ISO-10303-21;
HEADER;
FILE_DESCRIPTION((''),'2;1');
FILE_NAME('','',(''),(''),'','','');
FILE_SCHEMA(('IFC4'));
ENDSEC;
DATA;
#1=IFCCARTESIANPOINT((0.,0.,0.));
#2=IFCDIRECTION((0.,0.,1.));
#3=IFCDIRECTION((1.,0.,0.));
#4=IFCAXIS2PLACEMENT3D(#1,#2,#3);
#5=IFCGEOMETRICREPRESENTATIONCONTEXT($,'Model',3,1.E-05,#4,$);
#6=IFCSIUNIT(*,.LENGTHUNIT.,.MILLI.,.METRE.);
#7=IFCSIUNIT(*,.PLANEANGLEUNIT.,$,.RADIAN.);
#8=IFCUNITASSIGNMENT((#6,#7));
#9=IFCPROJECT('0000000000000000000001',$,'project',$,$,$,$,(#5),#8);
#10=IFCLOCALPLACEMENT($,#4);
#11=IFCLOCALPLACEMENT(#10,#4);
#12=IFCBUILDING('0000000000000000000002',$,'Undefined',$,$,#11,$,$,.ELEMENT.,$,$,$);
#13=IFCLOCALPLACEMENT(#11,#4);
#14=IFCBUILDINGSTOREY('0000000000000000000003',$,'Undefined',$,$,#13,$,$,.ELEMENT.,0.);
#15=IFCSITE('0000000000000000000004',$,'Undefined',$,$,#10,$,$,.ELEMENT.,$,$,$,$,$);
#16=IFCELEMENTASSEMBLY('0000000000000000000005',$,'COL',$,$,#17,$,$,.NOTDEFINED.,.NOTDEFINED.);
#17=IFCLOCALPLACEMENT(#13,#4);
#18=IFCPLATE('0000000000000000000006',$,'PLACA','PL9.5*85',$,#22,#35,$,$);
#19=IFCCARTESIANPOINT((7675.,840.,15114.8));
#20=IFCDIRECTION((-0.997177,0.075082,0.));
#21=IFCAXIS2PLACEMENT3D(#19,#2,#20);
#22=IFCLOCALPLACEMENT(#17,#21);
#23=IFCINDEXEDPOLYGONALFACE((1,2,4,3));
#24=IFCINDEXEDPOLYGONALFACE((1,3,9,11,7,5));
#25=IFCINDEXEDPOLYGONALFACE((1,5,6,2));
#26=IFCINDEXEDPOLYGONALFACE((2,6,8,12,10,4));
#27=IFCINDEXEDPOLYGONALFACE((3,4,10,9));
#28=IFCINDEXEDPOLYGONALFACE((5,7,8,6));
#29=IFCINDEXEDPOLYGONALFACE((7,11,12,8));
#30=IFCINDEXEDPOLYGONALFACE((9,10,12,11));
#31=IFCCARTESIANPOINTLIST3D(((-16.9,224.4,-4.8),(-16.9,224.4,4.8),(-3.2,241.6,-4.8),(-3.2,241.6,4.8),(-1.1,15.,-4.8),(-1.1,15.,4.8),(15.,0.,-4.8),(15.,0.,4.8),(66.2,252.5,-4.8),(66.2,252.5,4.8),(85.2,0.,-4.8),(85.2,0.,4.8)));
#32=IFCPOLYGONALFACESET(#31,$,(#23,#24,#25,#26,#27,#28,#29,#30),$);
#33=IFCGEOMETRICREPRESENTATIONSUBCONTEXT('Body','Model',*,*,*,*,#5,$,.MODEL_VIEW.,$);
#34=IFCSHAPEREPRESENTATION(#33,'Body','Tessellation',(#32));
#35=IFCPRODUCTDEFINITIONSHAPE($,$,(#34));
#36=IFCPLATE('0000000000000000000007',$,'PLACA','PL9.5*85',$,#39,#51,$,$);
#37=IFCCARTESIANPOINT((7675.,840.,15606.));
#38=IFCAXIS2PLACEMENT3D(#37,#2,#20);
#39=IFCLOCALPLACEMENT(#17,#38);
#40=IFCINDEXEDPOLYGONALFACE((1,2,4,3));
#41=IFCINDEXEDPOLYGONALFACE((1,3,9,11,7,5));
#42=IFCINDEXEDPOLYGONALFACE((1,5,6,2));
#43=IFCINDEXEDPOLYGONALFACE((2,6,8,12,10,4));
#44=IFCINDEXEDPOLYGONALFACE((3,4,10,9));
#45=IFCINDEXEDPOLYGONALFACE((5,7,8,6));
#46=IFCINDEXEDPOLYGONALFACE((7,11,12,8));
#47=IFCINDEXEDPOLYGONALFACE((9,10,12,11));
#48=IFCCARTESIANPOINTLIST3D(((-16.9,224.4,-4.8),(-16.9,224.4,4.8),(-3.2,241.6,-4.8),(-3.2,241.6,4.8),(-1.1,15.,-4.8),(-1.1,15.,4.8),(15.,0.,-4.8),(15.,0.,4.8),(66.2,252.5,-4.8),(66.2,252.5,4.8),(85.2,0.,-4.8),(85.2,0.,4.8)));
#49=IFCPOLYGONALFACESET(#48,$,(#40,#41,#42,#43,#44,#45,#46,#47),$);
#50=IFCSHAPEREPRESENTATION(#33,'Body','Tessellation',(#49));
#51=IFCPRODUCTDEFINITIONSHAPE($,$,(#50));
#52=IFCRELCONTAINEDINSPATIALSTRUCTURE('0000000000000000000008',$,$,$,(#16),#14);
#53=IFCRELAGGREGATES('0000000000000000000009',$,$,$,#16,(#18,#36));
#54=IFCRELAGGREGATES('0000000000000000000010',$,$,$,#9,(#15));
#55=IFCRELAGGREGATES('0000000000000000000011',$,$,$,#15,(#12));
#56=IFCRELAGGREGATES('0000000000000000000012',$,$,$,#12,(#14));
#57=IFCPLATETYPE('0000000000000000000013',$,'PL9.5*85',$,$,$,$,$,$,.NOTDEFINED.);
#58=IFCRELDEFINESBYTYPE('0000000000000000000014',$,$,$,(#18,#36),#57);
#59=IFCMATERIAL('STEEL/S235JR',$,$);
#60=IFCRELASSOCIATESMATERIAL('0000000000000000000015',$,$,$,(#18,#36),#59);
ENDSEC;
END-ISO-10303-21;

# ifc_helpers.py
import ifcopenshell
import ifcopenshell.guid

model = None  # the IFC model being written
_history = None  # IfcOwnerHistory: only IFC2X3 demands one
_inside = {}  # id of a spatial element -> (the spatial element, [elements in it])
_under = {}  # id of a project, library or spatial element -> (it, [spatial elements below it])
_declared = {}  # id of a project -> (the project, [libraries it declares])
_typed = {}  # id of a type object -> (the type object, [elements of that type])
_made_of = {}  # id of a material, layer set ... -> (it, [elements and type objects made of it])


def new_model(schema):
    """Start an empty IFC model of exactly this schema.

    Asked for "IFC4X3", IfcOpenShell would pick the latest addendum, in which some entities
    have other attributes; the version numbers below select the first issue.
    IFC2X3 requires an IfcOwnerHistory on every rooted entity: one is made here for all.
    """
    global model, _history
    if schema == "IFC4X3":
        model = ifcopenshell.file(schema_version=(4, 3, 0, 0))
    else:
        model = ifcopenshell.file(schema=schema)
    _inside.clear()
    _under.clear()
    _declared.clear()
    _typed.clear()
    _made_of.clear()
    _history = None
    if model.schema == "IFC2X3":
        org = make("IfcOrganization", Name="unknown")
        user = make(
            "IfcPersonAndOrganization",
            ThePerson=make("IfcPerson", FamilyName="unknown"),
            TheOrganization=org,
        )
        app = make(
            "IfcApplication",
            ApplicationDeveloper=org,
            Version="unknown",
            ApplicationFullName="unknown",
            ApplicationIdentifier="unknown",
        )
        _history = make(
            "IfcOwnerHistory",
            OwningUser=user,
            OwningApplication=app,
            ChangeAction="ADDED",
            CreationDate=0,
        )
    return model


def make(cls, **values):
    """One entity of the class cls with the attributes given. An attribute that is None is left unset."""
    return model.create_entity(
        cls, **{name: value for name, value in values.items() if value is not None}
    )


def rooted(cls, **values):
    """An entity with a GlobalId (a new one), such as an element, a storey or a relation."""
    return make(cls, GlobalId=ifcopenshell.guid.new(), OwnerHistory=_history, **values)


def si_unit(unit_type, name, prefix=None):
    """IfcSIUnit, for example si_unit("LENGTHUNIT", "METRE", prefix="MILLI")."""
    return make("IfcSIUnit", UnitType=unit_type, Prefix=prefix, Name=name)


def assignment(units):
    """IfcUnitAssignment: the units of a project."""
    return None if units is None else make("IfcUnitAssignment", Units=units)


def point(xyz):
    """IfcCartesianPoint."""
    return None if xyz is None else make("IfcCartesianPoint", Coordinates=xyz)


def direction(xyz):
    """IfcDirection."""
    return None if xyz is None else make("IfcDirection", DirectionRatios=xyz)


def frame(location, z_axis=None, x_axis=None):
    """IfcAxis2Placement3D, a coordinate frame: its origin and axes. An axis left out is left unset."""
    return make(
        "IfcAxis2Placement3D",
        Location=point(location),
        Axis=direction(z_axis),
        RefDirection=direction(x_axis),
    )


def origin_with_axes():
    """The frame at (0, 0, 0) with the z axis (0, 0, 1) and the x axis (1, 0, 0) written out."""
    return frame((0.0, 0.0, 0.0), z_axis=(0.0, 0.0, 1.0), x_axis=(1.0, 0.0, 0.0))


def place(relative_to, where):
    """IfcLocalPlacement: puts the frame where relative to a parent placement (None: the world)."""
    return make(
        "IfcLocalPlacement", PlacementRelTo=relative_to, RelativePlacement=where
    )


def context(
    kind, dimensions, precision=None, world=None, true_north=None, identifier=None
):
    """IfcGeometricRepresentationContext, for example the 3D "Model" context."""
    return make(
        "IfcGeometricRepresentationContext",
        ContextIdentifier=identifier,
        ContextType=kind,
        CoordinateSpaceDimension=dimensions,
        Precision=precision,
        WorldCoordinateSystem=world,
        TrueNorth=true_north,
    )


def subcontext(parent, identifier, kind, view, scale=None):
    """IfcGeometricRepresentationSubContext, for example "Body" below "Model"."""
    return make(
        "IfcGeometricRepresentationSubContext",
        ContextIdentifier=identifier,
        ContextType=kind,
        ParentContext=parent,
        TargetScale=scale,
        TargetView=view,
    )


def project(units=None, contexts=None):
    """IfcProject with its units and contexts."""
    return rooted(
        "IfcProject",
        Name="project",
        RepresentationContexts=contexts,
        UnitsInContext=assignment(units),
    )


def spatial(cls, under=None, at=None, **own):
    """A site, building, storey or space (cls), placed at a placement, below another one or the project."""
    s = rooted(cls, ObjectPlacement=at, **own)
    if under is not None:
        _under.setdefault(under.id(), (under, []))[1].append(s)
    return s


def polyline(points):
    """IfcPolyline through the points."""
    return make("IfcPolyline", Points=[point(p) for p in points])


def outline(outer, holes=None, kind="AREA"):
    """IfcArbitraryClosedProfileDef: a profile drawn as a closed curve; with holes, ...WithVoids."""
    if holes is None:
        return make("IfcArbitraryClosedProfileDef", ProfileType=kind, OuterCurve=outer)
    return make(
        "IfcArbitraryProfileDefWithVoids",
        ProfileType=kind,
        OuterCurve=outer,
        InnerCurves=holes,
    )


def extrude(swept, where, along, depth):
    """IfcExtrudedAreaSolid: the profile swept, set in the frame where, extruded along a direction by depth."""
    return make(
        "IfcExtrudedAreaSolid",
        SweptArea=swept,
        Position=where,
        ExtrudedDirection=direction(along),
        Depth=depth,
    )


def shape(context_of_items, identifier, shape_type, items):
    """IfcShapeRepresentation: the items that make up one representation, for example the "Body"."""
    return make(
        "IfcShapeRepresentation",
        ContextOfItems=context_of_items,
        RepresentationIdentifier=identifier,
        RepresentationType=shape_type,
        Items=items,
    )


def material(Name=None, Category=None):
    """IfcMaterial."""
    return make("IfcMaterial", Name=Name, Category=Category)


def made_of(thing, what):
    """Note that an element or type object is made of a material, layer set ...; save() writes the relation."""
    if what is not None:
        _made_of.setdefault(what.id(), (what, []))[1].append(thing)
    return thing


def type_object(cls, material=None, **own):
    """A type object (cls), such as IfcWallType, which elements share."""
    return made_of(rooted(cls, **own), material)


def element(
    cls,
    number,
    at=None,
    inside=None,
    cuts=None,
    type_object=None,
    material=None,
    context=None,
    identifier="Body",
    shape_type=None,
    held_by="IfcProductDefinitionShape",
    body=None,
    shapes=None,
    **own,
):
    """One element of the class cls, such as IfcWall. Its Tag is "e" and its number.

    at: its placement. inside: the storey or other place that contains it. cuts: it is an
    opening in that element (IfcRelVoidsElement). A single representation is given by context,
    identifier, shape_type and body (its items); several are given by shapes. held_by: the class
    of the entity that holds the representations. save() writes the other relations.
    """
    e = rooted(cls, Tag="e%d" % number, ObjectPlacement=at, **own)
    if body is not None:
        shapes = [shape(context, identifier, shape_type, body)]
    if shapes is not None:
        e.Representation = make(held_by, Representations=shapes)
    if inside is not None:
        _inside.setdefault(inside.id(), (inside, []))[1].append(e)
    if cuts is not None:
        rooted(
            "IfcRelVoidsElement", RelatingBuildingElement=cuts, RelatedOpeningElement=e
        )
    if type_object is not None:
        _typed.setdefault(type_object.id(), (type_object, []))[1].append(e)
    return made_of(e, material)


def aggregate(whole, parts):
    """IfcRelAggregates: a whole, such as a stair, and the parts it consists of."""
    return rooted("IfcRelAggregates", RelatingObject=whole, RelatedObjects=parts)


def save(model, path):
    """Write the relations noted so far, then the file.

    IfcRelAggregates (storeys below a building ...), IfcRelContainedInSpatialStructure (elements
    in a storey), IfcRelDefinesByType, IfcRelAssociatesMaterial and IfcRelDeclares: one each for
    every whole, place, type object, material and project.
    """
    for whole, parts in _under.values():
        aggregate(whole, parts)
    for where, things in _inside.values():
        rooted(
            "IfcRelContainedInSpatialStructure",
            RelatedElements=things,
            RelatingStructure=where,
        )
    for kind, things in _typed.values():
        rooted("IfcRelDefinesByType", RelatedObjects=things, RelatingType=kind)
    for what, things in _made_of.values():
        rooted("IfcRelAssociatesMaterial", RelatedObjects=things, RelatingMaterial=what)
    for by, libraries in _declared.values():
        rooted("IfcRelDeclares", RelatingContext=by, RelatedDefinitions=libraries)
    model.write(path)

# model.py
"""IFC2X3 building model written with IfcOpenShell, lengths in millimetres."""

from ifc_helpers import new_model, si_unit, frame, origin_with_axes, place, context, subcontext, project, spatial, polyline, outline, extrude, material, type_object, element, aggregate, save


model = new_model("IFC2X3")

# Units and contexts
model_context = context("Model", 3, precision=1e-05, world=origin_with_axes())
body_context = subcontext(model_context, "Body", "Model", "MODEL_VIEW")
ifc_project = project(units=[si_unit("LENGTHUNIT", "METRE", prefix="MILLI"), si_unit("PLANEANGLEUNIT", "RADIAN")], contexts=[model_context])

# Site, building, storey
site_placement = place(None, origin_with_axes())
site = spatial("IfcSite", under=ifc_project, at=site_placement, Name="Undefined", CompositionType="ELEMENT")
building_placement = place(site_placement, origin_with_axes())
building = spatial("IfcBuilding", under=site, at=building_placement, Name="Undefined", CompositionType="ELEMENT")
storey_placement = place(building_placement, origin_with_axes())
storey = spatial("IfcBuildingStorey", under=building, at=storey_placement, Name="Undefined", CompositionType="ELEMENT", Elevation=0.0)

# Shared definitions
ifc_material_1 = material(Name="STEEL/S235JR")

# Element assembly
assembly_1_placement = place(storey_placement, origin_with_axes())
assembly_1 = element("IfcElementAssembly", 1, at=assembly_1_placement, inside=storey, Name="COL", AssemblyPlace="NOTDEFINED", PredefinedType="NOTDEFINED")

# Plates
plate_type_1 = type_object("IfcPlateType", Name="PL9.5*85", PredefinedType="NOTDEFINED")
plate_1_placement = place(assembly_1_placement, frame((7675.0, 840.0, 15114.8), z_axis=(0.0, 0.0, 1.0), x_axis=(-0.997177, 0.075082, 0.0)))
plate_1 = element("IfcPlate", 2, at=plate_1_placement, type_object=plate_type_1, material=ifc_material_1, Name="PLACA", Description="PL9.5*85", context=body_context, shape_type="SweptSolid", body=[
    extrude(outline(polyline([(-1.1, 15.0), (15.0, 0.0), (85.2, 0.0), (66.2, 252.5), (-3.2, 241.6), (-16.9, 224.4), (-1.1, 15.0)])), frame((0.0, 0.0, -4.7), z_axis=(0.0, 0.0, 1.0), x_axis=(1.0, 0.0, 0.0)), (0.0, 0.0, 1.0), 9.5),
])
plate_2_placement = place(assembly_1_placement, frame((7675.0, 840.0, 15606.0), z_axis=(0.0, 0.0, 1.0), x_axis=(-0.997177, 0.075082, 0.0)))
plate_2 = element("IfcPlate", 3, at=plate_2_placement, type_object=plate_type_1, material=ifc_material_1, Name="PLACA", Description="PL9.5*85", context=body_context, shape_type="SweptSolid", body=[
    extrude(outline(polyline([(-1.1, 15.0), (15.0, 0.0), (85.2, 0.0), (66.2, 252.5), (-3.2, 241.6), (-16.9, 224.4), (-1.1, 15.0)])), frame((0.0, 0.0, -4.7), z_axis=(0.0, 0.0, 1.0), x_axis=(1.0, 0.0, 0.0)), (0.0, 0.0, 1.0), 9.5),
])
aggregate(assembly_1, [plate_1, plate_2])

save(model, "model.ifc")
